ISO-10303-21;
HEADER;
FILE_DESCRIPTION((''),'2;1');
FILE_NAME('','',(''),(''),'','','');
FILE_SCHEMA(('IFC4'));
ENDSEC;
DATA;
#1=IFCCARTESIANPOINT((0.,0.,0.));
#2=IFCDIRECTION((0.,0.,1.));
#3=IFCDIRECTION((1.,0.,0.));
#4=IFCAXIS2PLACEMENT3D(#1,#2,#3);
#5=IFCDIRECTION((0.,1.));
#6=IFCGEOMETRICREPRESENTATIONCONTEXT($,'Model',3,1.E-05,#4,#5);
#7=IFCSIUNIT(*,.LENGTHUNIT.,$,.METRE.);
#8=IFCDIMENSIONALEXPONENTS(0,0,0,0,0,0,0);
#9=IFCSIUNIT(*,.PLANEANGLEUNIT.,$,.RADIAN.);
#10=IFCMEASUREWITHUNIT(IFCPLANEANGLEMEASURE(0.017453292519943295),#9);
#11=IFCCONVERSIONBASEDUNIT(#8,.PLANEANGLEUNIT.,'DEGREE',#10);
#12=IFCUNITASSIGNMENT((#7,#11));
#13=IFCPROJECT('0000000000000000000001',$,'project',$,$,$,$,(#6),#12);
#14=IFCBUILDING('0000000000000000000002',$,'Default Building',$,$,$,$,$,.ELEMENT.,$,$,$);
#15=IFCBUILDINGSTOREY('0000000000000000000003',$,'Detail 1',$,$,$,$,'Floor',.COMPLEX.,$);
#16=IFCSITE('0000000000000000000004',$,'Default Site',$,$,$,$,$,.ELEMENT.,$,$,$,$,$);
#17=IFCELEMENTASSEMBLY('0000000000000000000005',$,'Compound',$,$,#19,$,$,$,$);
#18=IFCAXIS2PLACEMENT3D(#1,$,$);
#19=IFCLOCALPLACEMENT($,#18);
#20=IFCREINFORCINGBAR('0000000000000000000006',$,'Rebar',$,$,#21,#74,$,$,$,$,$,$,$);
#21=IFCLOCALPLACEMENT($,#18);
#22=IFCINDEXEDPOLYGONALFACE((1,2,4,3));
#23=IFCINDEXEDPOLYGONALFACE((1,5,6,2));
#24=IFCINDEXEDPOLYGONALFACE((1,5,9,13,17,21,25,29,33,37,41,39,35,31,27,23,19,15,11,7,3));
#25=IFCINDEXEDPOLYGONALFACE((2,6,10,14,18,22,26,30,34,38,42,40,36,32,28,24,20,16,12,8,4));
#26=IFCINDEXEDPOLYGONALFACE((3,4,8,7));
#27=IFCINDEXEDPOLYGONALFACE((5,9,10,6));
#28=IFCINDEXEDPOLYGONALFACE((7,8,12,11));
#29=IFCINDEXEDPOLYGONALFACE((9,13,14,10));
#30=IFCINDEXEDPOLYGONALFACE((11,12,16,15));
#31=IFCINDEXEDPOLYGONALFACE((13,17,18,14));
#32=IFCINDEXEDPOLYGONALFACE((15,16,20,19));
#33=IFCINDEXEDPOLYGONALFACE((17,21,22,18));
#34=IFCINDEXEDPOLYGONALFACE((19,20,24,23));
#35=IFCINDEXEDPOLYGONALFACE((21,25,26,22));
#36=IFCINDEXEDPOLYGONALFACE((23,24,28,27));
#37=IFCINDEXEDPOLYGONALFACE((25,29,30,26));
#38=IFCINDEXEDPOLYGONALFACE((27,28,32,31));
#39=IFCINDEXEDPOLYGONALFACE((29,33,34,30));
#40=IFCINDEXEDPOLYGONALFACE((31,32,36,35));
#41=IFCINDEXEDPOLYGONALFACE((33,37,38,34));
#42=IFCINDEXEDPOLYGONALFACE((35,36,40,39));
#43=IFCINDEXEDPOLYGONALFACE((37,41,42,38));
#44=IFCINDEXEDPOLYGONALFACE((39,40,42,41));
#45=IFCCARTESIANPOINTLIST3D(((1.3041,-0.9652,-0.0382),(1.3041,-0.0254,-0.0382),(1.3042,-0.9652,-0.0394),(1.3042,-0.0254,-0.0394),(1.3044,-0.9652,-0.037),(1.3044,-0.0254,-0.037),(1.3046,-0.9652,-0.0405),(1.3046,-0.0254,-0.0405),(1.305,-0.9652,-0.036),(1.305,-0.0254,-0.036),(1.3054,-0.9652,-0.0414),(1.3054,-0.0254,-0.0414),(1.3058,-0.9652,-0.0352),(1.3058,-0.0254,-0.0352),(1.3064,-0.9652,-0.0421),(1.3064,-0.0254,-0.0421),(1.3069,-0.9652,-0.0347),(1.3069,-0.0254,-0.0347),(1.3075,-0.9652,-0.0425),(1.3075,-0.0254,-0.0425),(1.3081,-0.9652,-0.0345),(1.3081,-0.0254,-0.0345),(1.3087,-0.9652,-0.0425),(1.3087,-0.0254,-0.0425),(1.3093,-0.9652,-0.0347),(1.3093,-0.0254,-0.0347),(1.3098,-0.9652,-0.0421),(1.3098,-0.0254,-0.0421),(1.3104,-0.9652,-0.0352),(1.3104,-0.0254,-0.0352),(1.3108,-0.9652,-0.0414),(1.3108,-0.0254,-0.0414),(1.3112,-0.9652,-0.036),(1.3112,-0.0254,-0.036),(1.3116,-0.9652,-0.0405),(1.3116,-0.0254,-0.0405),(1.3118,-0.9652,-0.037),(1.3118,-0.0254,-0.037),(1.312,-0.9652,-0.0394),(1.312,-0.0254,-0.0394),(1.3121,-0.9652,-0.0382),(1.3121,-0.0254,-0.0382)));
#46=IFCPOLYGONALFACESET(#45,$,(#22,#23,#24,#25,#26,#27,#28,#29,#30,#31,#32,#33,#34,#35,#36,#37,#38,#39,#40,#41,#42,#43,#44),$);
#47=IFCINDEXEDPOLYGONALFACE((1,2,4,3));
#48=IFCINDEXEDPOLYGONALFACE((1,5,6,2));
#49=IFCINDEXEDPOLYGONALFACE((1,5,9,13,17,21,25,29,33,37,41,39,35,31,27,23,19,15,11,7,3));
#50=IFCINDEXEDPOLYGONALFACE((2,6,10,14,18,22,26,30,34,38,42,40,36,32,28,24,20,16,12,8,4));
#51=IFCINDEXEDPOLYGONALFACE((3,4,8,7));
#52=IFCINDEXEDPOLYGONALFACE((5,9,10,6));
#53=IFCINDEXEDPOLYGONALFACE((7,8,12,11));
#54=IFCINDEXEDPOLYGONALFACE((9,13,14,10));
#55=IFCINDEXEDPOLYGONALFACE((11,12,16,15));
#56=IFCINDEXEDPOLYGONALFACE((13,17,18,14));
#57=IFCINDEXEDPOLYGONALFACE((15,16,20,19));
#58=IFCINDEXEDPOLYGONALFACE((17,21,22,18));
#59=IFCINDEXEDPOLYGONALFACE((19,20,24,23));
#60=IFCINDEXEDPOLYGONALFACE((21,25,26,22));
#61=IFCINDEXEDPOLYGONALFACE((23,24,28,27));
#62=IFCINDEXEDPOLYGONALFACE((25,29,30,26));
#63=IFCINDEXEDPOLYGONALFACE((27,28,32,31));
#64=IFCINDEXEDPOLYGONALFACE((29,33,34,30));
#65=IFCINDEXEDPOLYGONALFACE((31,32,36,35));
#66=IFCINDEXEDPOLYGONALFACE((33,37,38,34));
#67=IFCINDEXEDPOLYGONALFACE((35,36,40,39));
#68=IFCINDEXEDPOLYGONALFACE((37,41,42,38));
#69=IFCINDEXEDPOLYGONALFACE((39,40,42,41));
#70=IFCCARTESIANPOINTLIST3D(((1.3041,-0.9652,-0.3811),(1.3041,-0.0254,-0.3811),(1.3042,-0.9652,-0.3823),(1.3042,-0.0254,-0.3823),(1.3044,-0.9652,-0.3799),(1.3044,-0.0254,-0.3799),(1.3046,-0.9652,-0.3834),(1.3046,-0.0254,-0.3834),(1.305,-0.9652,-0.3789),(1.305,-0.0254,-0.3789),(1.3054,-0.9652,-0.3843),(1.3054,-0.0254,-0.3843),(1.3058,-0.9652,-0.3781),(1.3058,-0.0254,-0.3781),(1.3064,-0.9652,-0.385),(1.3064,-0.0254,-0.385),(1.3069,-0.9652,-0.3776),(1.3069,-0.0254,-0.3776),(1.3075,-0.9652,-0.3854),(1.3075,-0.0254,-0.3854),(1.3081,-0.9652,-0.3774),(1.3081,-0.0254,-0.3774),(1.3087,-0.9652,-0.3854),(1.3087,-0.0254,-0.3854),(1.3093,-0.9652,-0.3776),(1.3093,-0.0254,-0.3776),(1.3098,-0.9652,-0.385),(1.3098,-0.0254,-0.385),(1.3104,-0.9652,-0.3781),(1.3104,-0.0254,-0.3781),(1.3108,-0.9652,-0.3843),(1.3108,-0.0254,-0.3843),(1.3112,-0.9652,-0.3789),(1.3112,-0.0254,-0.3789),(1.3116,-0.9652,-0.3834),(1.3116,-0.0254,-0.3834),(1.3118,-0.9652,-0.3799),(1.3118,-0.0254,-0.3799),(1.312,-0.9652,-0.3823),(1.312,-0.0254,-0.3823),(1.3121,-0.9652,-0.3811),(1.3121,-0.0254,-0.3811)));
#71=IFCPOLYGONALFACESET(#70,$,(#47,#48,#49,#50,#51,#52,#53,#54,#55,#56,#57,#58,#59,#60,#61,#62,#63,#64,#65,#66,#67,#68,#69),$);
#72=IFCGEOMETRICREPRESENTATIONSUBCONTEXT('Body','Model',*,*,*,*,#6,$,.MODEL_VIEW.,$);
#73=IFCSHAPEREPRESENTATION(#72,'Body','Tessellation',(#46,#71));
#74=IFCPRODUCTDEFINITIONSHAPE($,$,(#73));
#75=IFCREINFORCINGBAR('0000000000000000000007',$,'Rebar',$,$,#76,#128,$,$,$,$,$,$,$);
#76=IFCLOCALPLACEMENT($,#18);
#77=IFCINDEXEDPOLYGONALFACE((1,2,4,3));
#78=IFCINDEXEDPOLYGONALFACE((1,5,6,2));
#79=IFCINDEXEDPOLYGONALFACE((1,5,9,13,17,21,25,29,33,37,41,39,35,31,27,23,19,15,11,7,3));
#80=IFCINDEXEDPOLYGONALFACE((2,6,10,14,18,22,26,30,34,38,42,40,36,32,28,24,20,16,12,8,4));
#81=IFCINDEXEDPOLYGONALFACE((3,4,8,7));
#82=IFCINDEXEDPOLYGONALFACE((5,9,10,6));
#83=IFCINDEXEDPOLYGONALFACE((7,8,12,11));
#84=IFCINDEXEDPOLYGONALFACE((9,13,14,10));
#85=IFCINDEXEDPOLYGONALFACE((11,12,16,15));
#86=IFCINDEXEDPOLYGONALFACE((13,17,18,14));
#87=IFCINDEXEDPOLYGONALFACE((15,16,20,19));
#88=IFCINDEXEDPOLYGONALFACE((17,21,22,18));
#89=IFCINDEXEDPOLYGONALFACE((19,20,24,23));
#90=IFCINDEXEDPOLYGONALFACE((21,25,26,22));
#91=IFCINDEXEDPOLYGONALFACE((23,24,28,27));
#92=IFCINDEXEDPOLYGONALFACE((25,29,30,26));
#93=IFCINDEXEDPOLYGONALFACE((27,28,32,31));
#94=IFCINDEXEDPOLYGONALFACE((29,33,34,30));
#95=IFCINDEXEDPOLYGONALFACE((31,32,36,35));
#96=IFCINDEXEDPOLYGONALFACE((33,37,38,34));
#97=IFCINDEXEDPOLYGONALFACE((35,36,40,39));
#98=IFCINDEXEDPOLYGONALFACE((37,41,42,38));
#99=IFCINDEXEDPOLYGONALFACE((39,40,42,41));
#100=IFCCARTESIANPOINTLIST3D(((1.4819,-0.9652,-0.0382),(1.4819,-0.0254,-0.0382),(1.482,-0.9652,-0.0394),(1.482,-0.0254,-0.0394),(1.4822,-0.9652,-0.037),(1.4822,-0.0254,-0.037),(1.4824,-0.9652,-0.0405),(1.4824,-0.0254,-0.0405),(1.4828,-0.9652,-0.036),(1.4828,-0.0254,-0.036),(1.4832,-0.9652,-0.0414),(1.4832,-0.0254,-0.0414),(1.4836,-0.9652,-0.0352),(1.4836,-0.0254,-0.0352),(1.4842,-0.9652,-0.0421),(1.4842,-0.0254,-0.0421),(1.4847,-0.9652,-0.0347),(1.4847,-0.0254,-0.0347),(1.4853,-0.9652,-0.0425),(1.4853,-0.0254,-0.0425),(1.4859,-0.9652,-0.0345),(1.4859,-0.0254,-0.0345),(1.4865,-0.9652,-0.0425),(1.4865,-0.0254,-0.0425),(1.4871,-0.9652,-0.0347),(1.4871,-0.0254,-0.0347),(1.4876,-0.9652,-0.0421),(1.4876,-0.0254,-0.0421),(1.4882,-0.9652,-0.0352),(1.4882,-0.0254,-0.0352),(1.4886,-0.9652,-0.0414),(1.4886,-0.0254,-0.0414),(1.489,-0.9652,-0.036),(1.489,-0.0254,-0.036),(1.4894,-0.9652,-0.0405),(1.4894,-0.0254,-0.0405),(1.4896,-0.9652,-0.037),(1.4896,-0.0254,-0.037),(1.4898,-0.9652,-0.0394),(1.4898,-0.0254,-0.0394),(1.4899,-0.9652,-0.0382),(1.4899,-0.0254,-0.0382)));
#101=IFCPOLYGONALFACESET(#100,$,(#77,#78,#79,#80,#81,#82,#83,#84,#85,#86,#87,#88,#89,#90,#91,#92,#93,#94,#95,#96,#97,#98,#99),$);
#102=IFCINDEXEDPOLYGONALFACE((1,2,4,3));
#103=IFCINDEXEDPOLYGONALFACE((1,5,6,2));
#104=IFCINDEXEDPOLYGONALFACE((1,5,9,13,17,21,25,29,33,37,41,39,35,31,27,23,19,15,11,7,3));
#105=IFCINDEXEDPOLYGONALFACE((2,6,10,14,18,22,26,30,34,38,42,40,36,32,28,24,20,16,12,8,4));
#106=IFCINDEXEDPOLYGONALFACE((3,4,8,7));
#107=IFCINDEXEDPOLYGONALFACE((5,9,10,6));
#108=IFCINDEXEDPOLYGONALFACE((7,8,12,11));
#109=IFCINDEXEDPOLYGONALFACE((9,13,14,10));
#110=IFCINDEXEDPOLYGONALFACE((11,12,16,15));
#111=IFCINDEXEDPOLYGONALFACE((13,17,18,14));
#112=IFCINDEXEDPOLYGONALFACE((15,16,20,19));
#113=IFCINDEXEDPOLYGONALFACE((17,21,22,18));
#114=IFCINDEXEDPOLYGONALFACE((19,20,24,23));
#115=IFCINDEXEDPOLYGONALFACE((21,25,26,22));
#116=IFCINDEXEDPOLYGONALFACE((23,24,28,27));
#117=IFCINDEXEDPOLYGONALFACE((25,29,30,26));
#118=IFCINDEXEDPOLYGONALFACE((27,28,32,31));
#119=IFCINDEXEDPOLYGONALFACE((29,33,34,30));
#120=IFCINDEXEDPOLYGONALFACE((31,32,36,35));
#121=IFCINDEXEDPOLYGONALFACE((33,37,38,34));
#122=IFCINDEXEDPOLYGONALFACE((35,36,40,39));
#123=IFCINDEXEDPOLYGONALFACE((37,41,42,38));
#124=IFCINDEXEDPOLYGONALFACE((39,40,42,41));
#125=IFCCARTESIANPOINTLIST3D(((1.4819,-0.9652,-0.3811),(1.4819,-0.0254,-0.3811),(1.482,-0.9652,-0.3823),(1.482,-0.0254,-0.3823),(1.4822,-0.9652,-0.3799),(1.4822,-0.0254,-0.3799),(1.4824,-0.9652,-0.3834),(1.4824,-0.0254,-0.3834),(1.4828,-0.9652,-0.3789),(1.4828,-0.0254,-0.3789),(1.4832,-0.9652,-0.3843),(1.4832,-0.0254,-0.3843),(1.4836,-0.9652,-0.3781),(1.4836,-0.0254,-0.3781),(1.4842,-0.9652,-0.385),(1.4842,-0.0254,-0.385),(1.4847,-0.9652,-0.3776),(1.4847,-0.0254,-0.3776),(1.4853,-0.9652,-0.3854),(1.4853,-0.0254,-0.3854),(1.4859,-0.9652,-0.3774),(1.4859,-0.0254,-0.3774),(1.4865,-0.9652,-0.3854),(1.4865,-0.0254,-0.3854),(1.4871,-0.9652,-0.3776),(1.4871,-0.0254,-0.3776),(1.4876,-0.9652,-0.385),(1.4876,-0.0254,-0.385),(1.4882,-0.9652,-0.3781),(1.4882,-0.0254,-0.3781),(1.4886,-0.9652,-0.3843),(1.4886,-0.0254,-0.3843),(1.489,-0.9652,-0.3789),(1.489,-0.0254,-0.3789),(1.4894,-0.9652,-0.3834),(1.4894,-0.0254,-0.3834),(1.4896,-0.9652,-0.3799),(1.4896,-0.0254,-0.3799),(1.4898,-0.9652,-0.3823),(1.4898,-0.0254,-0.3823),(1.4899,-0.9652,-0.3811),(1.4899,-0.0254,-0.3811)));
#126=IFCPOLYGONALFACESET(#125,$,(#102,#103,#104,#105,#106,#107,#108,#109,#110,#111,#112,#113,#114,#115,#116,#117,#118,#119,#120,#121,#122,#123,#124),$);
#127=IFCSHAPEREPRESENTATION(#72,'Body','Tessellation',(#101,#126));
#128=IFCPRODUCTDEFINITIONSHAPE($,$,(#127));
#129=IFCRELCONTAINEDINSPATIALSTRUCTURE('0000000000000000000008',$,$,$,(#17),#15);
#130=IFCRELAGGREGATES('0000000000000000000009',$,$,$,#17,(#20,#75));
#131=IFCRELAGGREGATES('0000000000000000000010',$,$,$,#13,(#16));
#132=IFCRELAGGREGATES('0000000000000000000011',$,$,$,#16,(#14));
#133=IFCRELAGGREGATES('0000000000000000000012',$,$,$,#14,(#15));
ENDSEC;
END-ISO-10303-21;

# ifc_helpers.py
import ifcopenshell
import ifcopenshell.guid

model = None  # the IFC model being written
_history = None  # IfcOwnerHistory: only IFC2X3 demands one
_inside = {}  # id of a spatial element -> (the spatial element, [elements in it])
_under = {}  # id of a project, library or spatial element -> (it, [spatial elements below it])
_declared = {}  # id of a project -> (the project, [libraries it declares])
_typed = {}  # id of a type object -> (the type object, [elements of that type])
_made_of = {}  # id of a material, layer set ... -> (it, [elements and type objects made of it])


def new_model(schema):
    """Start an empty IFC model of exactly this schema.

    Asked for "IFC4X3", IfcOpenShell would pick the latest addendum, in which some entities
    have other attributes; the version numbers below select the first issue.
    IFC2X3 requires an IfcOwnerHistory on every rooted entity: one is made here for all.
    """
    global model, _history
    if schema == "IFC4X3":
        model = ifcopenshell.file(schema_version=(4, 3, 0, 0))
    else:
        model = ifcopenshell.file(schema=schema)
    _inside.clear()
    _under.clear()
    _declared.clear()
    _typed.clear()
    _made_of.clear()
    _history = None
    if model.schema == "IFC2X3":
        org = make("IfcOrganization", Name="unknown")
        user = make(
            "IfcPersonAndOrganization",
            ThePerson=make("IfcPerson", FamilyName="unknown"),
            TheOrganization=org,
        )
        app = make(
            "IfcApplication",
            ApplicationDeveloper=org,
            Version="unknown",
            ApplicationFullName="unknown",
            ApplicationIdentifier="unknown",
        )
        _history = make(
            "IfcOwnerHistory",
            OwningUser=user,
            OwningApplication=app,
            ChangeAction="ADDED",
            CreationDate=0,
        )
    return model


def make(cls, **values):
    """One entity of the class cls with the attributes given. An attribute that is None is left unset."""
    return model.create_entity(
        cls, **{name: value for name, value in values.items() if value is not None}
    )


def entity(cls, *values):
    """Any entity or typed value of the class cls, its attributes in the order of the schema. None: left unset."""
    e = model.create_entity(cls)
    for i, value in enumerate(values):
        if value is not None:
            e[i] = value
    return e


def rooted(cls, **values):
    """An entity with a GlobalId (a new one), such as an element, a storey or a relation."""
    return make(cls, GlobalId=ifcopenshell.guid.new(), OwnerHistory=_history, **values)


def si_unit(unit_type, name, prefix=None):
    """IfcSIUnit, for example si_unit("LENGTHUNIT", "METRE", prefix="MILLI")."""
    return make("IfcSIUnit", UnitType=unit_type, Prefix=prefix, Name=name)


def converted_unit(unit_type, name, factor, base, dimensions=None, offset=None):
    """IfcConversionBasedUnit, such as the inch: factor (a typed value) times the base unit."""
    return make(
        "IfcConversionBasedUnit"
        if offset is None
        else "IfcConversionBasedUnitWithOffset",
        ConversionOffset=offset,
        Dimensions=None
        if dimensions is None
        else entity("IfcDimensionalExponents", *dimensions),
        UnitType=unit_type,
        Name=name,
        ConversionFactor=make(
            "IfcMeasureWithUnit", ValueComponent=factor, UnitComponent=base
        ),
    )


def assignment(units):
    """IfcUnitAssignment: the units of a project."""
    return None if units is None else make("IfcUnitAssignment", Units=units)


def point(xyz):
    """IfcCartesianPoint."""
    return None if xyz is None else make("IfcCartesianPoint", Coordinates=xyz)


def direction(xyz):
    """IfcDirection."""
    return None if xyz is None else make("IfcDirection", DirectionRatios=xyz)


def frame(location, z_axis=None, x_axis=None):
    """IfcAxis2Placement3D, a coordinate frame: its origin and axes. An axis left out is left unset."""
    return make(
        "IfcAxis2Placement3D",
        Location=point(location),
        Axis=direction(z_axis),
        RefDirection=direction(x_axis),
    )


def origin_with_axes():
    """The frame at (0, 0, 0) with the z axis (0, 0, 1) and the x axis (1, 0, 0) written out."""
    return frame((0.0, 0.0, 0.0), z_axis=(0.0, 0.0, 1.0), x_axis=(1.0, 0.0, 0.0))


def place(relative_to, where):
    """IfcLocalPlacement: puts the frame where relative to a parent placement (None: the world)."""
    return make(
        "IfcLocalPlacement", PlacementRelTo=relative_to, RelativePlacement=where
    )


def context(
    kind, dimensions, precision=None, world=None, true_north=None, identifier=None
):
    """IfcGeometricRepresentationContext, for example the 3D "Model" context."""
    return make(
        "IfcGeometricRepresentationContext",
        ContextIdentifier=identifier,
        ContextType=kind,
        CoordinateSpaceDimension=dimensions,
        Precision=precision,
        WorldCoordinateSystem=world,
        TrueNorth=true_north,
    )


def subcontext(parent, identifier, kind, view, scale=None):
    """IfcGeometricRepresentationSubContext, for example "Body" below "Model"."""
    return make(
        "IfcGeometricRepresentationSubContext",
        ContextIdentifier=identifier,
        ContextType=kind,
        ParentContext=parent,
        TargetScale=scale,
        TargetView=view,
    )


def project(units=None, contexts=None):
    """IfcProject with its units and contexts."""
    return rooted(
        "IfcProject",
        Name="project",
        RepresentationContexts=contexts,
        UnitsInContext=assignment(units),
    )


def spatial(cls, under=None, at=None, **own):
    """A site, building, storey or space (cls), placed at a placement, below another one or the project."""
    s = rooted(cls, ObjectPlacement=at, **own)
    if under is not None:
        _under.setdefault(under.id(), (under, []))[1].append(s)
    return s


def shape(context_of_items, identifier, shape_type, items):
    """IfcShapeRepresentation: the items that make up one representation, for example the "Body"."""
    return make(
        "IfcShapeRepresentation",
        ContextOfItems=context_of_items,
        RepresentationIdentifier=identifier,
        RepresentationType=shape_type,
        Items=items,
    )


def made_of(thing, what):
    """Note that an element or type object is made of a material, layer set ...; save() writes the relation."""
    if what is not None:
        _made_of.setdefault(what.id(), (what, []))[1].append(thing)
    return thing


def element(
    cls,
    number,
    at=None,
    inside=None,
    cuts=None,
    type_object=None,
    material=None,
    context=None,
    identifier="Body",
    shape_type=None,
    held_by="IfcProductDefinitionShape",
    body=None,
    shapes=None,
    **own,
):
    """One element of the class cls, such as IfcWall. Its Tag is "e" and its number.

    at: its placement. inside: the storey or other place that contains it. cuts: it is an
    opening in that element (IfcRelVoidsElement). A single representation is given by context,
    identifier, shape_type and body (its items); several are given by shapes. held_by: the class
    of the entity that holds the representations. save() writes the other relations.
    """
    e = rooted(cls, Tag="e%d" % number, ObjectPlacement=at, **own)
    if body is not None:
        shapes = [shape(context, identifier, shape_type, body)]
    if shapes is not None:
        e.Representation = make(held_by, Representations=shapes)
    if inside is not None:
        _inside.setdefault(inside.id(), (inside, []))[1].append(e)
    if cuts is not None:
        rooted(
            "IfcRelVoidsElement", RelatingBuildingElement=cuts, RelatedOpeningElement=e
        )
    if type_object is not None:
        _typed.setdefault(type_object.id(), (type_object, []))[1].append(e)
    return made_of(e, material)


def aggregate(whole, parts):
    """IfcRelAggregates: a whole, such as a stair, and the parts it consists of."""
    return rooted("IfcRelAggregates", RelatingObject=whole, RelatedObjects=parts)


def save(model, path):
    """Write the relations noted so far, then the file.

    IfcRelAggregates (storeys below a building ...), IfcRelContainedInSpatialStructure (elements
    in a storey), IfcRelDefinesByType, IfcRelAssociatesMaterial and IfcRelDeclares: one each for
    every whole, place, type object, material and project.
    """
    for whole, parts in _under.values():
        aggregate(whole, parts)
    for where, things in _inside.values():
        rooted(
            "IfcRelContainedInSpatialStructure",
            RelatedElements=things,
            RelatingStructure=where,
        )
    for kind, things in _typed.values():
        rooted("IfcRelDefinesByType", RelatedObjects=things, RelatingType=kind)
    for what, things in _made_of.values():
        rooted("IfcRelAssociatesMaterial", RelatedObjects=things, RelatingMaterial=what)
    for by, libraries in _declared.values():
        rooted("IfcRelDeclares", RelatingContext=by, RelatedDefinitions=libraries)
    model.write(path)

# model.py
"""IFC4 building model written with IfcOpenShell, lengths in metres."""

from ifc_helpers import new_model, entity, si_unit, converted_unit, direction, origin_with_axes, place, context, subcontext, project, spatial, element, aggregate, save


model = new_model("IFC4")

# Units and contexts
model_context = context("Model", 3, precision=1e-05, world=origin_with_axes(), true_north=direction((0.0, 1.0)))
body_context = subcontext(model_context, "Body", "Model", "MODEL_VIEW")
ifc_project = project(units=[si_unit("LENGTHUNIT", "METRE"), converted_unit("PLANEANGLEUNIT", "DEGREE", entity("IfcPlaneAngleMeasure", 0.017453292519943295), si_unit("PLANEANGLEUNIT", "RADIAN"), dimensions=[0, 0, 0, 0, 0, 0, 0])], contexts=[model_context])

# Site, building, storey
site = spatial("IfcSite", under=ifc_project, Name="Default Site", CompositionType="ELEMENT")
building = spatial("IfcBuilding", under=site, Name="Default Building", CompositionType="ELEMENT")
storey = spatial("IfcBuildingStorey", under=building, Name="Detail 1", LongName="Floor", CompositionType="COMPLEX")

# Shared definitions
placement = place(None, origin_with_axes())

# Element assembly, reinforcing bars
assembly = element("IfcElementAssembly", 1, inside=storey, Name="Compound")
reinforcing_bar_1 = element("IfcReinforcingBar", 2, at=placement, Name="Rebar", context=body_context, shape_type="SweptSolid", body=[
    entity("IfcSweptDiskSolid", entity("IfcCompositeCurve", [entity("IfcCompositeCurveSegment", "CONTINUOUS", True, entity("IfcPolyline", [entity("IfcCartesianPoint", [1.3081, -0.9652, -0.0385]), entity("IfcCartesianPoint", [1.3081, -0.0254, -0.0385])]))], False), 0.004),
    entity("IfcSweptDiskSolid", entity("IfcCompositeCurve", [entity("IfcCompositeCurveSegment", "CONTINUOUS", True, entity("IfcPolyline", [entity("IfcCartesianPoint", [1.3081, -0.9652, -0.3814]), entity("IfcCartesianPoint", [1.3081, -0.0254, -0.3814])]))], False), 0.004),
])
reinforcing_bar_2 = element("IfcReinforcingBar", 3, at=placement, Name="Rebar", context=body_context, shape_type="SweptSolid", body=[
    entity("IfcSweptDiskSolid", entity("IfcCompositeCurve", [entity("IfcCompositeCurveSegment", "CONTINUOUS", True, entity("IfcPolyline", [entity("IfcCartesianPoint", [1.4859, -0.9652, -0.0385]), entity("IfcCartesianPoint", [1.4859, -0.0254, -0.0385])]))], False), 0.004),
    entity("IfcSweptDiskSolid", entity("IfcCompositeCurve", [entity("IfcCompositeCurveSegment", "CONTINUOUS", True, entity("IfcPolyline", [entity("IfcCartesianPoint", [1.4859, -0.9652, -0.3814]), entity("IfcCartesianPoint", [1.4859, -0.0254, -0.3814])]))], False), 0.004),
])
aggregate(assembly, [reinforcing_bar_1, reinforcing_bar_2])

save(model, "model.ifc")
